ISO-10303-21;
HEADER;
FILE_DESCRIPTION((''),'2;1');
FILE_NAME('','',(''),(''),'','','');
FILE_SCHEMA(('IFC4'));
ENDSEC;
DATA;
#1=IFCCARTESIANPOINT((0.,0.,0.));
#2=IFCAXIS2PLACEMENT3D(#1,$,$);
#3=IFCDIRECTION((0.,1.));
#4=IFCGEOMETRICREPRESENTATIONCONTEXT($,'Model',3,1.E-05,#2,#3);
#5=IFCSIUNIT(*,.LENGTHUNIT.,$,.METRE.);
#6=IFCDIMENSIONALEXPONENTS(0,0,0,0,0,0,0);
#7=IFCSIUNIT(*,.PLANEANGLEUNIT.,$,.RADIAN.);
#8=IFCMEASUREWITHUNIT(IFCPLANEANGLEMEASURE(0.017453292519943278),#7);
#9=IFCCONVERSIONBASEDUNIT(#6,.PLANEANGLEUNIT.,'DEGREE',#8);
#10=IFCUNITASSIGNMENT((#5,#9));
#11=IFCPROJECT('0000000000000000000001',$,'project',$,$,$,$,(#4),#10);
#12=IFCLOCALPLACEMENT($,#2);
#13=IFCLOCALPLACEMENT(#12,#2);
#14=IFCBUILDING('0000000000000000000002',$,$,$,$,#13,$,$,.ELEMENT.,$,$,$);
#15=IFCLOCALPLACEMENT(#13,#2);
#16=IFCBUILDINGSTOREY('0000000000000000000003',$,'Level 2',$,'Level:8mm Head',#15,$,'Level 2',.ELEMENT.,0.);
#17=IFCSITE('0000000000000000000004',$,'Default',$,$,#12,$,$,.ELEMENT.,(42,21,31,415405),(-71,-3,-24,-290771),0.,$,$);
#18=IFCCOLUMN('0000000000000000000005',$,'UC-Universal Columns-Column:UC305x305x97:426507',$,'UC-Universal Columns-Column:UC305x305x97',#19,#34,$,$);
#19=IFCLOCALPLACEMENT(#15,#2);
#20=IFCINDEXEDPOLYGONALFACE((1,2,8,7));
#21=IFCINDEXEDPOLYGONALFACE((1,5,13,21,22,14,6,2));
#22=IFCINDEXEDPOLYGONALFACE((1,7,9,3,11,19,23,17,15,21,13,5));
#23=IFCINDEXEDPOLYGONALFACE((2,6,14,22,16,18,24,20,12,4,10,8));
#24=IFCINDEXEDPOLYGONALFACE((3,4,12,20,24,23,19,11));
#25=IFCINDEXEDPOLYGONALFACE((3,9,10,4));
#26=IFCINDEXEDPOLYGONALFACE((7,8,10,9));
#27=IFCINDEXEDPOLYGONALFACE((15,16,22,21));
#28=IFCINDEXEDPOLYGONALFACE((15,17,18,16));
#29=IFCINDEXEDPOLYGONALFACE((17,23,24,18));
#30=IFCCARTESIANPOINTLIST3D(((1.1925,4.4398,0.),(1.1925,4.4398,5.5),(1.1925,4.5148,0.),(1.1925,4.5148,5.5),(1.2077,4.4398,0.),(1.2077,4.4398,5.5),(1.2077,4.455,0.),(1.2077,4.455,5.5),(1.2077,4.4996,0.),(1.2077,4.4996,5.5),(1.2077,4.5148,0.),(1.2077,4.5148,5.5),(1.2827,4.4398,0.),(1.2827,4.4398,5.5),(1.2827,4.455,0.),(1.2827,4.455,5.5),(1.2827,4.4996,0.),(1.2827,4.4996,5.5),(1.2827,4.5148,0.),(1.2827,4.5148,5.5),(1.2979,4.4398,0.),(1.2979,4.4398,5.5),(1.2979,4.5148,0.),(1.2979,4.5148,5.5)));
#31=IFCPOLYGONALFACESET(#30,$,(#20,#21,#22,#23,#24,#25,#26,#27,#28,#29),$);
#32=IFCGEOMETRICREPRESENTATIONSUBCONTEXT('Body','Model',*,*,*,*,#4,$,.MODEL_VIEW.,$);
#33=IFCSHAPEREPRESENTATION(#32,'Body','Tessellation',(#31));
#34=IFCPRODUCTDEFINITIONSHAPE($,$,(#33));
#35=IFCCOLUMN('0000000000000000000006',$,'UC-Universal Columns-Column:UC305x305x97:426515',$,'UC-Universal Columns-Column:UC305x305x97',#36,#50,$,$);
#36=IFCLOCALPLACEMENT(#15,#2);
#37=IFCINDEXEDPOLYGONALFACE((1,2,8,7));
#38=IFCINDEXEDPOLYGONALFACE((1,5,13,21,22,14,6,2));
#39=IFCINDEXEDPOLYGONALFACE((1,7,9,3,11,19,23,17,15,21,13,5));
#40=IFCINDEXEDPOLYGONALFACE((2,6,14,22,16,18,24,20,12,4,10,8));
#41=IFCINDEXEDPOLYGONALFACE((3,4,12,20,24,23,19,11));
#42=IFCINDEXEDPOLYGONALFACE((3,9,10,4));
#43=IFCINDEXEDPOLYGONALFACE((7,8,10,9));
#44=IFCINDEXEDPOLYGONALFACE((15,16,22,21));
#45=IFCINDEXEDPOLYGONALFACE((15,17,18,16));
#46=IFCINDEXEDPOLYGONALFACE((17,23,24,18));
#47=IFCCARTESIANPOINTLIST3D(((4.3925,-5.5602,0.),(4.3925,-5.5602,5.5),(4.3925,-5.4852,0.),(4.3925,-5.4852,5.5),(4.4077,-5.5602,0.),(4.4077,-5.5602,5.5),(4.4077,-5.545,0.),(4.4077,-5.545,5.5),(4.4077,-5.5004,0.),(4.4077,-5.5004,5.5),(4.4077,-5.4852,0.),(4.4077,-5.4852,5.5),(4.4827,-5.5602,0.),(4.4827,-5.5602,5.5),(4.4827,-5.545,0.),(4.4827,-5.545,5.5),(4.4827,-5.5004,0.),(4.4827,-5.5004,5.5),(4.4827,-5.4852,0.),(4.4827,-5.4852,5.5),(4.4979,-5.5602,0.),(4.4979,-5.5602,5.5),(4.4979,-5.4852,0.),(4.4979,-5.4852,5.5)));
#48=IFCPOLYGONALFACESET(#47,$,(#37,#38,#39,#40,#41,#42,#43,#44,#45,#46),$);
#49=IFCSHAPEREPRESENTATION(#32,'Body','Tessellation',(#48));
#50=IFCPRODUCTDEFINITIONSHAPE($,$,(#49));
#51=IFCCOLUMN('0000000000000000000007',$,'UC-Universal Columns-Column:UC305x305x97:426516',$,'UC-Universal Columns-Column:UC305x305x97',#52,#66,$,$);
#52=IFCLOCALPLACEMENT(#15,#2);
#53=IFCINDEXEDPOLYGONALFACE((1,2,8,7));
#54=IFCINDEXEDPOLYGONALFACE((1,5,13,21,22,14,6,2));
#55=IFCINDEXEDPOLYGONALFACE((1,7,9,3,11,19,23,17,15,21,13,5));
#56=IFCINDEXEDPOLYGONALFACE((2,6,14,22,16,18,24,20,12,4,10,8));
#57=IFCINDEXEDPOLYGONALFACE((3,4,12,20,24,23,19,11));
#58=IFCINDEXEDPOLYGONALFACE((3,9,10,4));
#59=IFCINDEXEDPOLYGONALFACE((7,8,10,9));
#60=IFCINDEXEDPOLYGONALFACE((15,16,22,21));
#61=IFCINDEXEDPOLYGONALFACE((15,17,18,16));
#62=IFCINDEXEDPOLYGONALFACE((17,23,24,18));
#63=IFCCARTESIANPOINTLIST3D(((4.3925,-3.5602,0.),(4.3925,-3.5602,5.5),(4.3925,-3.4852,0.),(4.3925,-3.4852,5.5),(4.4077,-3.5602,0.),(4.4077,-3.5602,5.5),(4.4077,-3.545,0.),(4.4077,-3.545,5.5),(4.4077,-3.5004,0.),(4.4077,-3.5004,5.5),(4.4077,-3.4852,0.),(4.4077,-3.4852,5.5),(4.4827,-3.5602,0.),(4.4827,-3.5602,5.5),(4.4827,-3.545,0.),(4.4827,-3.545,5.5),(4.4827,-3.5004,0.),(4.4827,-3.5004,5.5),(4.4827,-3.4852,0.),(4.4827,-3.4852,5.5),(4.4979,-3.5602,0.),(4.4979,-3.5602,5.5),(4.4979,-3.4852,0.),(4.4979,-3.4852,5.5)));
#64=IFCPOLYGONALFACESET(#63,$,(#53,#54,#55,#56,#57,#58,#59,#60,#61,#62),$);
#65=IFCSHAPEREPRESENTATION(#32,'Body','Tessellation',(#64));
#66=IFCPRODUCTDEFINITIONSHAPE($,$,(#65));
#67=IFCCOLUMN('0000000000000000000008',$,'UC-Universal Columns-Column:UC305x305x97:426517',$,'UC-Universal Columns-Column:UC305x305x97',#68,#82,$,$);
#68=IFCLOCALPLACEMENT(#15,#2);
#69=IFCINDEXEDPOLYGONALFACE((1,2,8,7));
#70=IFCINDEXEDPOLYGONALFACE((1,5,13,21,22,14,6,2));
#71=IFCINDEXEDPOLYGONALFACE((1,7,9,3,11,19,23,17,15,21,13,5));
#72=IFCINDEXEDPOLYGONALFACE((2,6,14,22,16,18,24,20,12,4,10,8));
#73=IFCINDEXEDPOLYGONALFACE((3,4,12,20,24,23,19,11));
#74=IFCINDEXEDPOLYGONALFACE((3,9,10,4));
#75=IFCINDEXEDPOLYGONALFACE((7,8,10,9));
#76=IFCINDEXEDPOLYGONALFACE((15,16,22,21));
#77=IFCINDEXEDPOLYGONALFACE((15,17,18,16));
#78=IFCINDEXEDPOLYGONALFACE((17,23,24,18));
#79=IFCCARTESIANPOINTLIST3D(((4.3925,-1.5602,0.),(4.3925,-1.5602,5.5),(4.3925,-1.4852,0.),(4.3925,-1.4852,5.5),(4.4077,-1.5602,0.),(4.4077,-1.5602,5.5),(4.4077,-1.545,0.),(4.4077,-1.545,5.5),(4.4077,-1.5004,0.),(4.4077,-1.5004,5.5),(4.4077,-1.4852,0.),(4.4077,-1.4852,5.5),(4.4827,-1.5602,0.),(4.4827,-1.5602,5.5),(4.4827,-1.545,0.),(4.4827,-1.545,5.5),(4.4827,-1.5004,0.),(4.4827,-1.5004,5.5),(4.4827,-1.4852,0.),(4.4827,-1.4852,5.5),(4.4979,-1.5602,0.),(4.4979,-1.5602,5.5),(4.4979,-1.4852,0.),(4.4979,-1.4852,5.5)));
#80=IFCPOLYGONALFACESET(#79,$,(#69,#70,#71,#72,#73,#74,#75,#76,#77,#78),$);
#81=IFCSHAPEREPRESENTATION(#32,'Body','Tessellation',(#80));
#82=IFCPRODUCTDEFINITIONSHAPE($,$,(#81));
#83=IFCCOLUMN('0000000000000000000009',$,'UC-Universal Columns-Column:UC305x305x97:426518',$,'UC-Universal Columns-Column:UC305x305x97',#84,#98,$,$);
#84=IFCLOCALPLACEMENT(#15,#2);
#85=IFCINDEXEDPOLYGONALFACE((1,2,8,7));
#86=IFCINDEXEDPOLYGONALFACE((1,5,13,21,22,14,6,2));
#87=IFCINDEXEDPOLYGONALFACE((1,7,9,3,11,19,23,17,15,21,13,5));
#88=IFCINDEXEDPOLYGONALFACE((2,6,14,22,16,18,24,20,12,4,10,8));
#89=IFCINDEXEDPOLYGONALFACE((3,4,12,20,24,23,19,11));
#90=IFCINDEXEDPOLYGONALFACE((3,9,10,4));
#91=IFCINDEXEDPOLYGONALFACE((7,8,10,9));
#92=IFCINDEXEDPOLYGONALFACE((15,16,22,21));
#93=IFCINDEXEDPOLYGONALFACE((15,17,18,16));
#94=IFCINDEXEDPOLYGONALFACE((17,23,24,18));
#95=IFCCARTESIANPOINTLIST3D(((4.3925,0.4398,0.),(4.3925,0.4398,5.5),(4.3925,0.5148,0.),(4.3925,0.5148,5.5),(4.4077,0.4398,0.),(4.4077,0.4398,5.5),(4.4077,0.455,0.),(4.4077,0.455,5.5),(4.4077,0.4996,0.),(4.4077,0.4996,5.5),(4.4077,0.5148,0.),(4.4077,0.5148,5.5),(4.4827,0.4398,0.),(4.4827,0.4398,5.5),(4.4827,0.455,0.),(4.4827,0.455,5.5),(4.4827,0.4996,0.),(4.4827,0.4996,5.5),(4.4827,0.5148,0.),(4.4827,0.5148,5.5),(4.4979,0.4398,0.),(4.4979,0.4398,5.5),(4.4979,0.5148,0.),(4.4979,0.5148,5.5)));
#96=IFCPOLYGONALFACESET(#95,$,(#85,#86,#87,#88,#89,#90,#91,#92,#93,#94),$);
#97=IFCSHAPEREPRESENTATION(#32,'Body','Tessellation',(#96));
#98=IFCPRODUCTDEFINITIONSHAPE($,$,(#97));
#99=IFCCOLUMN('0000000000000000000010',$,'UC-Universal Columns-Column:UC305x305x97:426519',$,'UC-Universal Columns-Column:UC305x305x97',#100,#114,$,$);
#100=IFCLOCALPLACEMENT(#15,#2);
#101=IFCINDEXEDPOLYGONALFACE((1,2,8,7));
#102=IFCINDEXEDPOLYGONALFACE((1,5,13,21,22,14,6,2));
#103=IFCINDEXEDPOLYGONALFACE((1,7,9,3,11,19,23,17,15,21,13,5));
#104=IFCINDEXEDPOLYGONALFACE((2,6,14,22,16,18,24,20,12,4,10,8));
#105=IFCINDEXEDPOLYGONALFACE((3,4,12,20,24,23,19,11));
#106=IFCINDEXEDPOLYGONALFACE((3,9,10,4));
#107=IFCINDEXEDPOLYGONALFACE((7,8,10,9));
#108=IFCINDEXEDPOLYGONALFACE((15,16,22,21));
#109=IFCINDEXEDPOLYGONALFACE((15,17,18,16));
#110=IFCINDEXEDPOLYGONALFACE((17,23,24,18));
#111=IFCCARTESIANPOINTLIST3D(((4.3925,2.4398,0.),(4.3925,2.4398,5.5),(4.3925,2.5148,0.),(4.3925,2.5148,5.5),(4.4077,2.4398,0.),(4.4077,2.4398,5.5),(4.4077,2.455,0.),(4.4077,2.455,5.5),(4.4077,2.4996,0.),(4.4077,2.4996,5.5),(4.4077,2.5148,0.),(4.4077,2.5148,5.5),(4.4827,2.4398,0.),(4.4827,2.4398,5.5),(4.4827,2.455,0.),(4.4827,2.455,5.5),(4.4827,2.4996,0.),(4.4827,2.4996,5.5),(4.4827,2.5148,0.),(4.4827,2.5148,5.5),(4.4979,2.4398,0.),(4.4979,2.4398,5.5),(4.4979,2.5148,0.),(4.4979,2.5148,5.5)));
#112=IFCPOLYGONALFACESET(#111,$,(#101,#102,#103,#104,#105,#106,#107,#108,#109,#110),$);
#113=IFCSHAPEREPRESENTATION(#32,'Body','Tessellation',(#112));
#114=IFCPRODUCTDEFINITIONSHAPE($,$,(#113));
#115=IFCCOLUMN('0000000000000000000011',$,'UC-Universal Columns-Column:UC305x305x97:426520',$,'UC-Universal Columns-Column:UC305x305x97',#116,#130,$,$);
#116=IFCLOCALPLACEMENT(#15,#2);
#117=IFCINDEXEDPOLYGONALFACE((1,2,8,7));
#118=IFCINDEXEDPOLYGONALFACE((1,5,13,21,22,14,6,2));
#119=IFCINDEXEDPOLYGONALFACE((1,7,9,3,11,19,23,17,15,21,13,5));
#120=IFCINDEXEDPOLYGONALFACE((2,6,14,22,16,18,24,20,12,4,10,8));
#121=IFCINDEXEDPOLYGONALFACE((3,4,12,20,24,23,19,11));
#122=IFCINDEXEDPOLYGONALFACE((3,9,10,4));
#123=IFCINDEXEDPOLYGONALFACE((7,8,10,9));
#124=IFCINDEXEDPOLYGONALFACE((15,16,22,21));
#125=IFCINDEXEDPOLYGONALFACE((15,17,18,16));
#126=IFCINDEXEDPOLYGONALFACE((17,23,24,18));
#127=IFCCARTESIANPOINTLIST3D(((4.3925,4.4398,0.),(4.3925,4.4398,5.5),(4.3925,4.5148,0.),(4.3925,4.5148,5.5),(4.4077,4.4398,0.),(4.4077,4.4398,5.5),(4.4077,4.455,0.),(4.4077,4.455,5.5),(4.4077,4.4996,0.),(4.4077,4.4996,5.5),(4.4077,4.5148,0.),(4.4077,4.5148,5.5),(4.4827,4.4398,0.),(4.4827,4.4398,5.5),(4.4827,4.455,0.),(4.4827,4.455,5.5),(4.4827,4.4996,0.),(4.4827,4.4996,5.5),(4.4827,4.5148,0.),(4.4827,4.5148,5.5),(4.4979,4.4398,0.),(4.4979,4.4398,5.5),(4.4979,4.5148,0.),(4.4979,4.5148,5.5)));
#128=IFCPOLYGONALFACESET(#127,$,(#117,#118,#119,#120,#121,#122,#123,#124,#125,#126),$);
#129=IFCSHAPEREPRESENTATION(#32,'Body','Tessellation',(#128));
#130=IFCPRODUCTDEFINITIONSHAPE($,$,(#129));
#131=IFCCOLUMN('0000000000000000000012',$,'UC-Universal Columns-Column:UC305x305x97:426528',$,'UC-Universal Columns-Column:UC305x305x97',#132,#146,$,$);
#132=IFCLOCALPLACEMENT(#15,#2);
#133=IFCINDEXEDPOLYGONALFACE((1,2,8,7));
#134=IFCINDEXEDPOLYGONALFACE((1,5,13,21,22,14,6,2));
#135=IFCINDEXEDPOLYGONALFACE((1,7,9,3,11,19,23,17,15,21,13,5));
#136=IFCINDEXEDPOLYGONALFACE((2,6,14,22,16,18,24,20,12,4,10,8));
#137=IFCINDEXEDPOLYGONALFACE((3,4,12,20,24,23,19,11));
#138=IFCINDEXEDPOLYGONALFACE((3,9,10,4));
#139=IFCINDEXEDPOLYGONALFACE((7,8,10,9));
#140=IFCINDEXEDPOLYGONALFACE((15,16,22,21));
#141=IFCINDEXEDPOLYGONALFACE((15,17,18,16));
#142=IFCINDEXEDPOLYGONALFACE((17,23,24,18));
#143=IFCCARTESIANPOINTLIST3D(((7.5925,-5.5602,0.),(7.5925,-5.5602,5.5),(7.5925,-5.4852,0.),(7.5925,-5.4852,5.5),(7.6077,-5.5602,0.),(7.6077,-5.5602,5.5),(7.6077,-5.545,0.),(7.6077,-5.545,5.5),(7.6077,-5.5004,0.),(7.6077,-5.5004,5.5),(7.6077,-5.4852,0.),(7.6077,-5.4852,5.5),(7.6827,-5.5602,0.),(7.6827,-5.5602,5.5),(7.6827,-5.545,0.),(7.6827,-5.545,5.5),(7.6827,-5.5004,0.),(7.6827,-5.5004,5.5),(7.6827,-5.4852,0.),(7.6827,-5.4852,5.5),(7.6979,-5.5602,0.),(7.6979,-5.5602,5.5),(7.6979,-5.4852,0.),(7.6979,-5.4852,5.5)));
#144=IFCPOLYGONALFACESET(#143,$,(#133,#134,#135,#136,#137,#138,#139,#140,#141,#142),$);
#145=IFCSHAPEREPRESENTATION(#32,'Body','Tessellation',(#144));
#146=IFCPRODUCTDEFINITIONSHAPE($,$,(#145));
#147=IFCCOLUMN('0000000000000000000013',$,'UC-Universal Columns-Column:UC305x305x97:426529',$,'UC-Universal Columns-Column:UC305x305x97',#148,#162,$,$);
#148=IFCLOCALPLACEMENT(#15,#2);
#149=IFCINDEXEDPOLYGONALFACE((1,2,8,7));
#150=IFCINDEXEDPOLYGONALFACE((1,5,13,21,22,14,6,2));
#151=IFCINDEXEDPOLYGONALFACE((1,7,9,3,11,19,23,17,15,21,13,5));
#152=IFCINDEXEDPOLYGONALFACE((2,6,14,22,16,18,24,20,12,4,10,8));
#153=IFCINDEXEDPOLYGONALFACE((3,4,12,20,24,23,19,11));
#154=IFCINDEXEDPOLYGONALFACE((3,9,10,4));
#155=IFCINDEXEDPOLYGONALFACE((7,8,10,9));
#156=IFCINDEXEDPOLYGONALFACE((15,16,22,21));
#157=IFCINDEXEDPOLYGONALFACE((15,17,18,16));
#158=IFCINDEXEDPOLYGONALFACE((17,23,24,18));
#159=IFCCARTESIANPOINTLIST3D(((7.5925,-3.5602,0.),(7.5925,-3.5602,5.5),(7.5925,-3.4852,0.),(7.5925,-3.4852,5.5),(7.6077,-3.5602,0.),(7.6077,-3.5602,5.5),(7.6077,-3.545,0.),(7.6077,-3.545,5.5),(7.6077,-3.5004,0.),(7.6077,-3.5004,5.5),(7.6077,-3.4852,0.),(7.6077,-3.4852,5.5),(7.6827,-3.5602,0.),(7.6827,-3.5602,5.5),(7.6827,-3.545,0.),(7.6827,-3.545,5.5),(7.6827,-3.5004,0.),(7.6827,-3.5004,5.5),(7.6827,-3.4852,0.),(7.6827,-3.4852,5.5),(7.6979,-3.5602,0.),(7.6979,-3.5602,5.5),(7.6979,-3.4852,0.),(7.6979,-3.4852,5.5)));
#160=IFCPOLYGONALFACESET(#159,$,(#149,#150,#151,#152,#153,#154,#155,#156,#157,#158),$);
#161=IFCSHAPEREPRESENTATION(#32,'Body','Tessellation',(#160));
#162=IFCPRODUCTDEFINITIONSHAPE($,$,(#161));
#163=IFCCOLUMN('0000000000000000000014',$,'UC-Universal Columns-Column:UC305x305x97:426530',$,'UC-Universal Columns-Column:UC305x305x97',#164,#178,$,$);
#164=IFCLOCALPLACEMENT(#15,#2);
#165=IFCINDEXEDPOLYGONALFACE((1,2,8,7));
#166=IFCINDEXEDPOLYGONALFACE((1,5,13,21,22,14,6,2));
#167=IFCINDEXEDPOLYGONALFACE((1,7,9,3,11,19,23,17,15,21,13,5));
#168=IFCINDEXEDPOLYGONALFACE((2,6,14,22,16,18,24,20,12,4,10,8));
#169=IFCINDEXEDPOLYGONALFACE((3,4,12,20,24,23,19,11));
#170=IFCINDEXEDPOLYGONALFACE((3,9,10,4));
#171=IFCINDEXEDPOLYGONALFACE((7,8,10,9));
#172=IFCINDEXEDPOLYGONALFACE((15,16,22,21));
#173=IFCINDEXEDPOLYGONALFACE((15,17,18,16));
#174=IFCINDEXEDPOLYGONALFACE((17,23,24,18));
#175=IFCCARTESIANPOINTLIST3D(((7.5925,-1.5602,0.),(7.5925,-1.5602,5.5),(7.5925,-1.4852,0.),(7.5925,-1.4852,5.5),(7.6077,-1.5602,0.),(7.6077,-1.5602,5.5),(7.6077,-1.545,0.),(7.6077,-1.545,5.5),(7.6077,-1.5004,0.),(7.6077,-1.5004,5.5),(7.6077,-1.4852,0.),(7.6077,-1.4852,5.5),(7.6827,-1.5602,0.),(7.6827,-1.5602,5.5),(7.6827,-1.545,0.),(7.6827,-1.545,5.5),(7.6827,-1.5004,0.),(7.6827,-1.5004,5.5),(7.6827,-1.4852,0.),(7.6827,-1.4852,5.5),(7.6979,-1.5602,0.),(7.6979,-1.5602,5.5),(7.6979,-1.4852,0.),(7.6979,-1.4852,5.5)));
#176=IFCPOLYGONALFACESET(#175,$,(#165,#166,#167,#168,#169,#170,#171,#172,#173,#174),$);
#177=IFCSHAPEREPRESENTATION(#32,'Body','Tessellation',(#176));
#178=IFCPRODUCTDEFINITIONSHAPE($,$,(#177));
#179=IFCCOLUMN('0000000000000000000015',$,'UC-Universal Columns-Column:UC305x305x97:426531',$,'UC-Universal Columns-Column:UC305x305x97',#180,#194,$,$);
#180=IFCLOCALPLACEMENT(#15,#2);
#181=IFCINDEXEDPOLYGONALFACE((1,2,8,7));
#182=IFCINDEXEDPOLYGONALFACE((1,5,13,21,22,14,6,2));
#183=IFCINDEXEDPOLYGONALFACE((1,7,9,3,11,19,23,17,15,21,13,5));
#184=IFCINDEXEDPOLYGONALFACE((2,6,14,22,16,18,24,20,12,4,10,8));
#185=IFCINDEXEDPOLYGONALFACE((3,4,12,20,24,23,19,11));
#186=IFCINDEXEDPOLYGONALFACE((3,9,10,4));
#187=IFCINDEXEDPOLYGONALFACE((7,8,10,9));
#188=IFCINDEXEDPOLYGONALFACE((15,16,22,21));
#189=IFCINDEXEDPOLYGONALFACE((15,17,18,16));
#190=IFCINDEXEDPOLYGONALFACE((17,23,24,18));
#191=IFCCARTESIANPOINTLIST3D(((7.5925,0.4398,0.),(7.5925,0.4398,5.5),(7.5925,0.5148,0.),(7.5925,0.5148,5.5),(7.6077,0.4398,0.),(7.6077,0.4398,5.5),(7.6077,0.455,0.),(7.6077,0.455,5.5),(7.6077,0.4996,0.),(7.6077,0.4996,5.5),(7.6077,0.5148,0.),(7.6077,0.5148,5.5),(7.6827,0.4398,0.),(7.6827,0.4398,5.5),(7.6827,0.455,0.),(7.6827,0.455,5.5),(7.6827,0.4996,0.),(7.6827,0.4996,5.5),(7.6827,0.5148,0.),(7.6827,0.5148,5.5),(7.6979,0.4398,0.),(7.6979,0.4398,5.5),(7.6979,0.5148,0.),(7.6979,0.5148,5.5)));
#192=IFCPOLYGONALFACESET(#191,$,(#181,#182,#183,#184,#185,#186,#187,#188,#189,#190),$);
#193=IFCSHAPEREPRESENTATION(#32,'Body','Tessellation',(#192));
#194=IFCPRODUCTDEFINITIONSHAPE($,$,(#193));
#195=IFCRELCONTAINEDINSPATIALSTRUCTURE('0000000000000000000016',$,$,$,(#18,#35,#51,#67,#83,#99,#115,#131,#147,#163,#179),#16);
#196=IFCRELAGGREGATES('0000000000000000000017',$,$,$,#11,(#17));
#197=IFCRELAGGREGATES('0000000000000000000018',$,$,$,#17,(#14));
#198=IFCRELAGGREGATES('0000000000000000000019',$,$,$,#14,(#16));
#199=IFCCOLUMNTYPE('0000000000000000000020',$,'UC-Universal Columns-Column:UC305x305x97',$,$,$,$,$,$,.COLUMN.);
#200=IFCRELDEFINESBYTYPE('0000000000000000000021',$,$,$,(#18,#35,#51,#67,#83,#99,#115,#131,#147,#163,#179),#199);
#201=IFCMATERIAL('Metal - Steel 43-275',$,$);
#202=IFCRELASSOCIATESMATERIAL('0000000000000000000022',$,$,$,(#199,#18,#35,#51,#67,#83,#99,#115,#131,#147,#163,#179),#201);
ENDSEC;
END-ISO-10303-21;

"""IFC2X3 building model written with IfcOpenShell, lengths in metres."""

from ifc_helpers import new_model, entity, si_unit, converted_unit, direction, frame, frame_2d, origin, place, context, subcontext, project, spatial, polyline, circle_curve, parameter, trimmed, segment, composite_curve, outline, extrude, source, transform, mapped, material, type_object, type_shapes, element, save


model = new_model("IFC2X3")

# Units and contexts
model_context = context("Model", 3, precision=1e-05, world=origin(), true_north=direction((0.0, 1.0)))
body_context = subcontext(model_context, "Body", "Model", "MODEL_VIEW")
ifc_project = project(units=[si_unit("LENGTHUNIT", "METRE"), converted_unit("PLANEANGLEUNIT", "DEGREE", entity("IfcPlaneAngleMeasure", 0.017453292519943278), si_unit("PLANEANGLEUNIT", "RADIAN"), dimensions=[0, 0, 0, 0, 0, 0, 0])], contexts=[model_context])

# Site, building, storey
site_placement = place(None, origin())
site = spatial("IfcSite", under=ifc_project, at=site_placement, Name="Default", CompositionType="ELEMENT", RefLatitude=(42, 21, 31, 415405), RefLongitude=(-71, -3, -24, -290771), RefElevation=0.0)
building_placement = place(site_placement, origin())
building = spatial("IfcBuilding", under=site, at=building_placement, CompositionType="ELEMENT")
storey_placement = place(building_placement, origin())
storey = spatial("IfcBuildingStorey", under=building, at=storey_placement, Name="Level 2", ObjectType="Level:8mm Head", LongName="Level 2", CompositionType="ELEMENT", Elevation=0.0)

# Columns
ifc_material_1 = material(Name="Metal - Steel 43-275")
column_type_1 = type_object("IfcColumnType", Name="UC-Universal Columns-Column:UC305x305x97", PredefinedType="COLUMN", material=ifc_material_1)
shared_shape_1 = source(origin(), body_context, "Body", "SweptSolid", [
    extrude(outline(composite_curve([segment(polyline([(-0.0375, -0.0375), (0.0375, -0.0375)]), True, "CONTINUOUS"), segment(polyline([(0.0375, -0.0375), (0.0527, -0.0375)]), True, "CONTINUOUS"), segment(trimmed(circle_curve(frame_2d((0.0527, -0.0223), x_axis=(-1.0, 0.0)), 0.0152), [parameter(0.0)], [parameter(90.0)], True, "PARAMETER"), False, "CONTINUOUS"), segment(polyline([(0.0375, -0.0223), (0.0375, 0.0223)]), True, "CONTINUOUS"), segment(trimmed(circle_curve(frame_2d((0.0527, 0.0223), x_axis=(-1.0, 0.0)), 0.0152), [parameter(270.0)], [parameter(0.0)], True, "PARAMETER"), False, "CONTINUOUS"), segment(polyline([(0.0527, 0.0375), (0.0375, 0.0375)]), True, "CONTINUOUS"), segment(polyline([(0.0375, 0.0375), (-0.0375, 0.0375)]), True, "CONTINUOUS"), segment(polyline([(-0.0375, 0.0375), (-0.0527, 0.0375)]), True, "CONTINUOUS"), segment(trimmed(circle_curve(frame_2d((-0.0527, 0.0223), x_axis=(-1.0, 0.0)), 0.0152), [parameter(180.0)], [parameter(270.0)], True, "PARAMETER"), False, "CONTINUOUS"), segment(polyline([(-0.0375, 0.0223), (-0.0375, -0.0223)]), True, "CONTINUOUS"), segment(trimmed(circle_curve(frame_2d((-0.0527, -0.0223), x_axis=(-1.0, 0.0)), 0.0152), [parameter(90.0)], [parameter(180.0)], True, "PARAMETER"), False, "CONTINUOUS"), segment(polyline([(-0.0527, -0.0375), (-0.0375, -0.0375)]), True, "CONTINUOUS")], self_intersect=False)), frame((0.0, 0.0, 0.0), z_axis=(0.0, 0.0, 1.0), x_axis=(-1.0, 0.0, 0.0)), (0.0, 0.0, 1.0), 5.5),
])
type_shapes(column_type_1, [shared_shape_1])
for number, where, z_axis, x_axis, name in (
    (1, (1.2452, 4.4773, 0.0), (0.0, 0.0, 1.0), (-1.0, 0.0, 0.0), "UC-Universal Columns-Column:UC305x305x97:426507"),
    (2, (4.4452, -5.5227, 0.0), (0.0, 0.0, 1.0), (-1.0, 0.0, 0.0), "UC-Universal Columns-Column:UC305x305x97:426515"),
    (3, (4.4452, -3.5227, 0.0), (0.0, 0.0, 1.0), (-1.0, 0.0, 0.0), "UC-Universal Columns-Column:UC305x305x97:426516"),
    (4, (4.4452, -1.5227, 0.0), (0.0, 0.0, 1.0), (-1.0, 0.0, 0.0), "UC-Universal Columns-Column:UC305x305x97:426517"),
    (5, (4.4452, 0.4773, 0.0), (0.0, 0.0, 1.0), (-1.0, 0.0, 0.0), "UC-Universal Columns-Column:UC305x305x97:426518"),
    (6, (4.4452, 2.4773, 0.0), (0.0, 0.0, 1.0), (-1.0, 0.0, 0.0), "UC-Universal Columns-Column:UC305x305x97:426519"),
    (7, (4.4452, 4.4773, 0.0), (0.0, 0.0, 1.0), (-1.0, 0.0, 0.0), "UC-Universal Columns-Column:UC305x305x97:426520"),
    (8, (7.6452, -5.5227, 0.0), (0.0, 0.0, 1.0), (-1.0, 0.0, 0.0), "UC-Universal Columns-Column:UC305x305x97:426528"),
    (9, (7.6452, -3.5227, 0.0), (0.0, 0.0, 1.0), (-1.0, 0.0, 0.0), "UC-Universal Columns-Column:UC305x305x97:426529"),
    (10, (7.6452, -1.5227, 0.0), (0.0, 0.0, 1.0), (-1.0, 0.0, 0.0), "UC-Universal Columns-Column:UC305x305x97:426530"),
    (11, (7.6452, 0.4773, 0.0), (0.0, 0.0, 1.0), (-1.0, 0.0, 0.0), "UC-Universal Columns-Column:UC305x305x97:426531"),
):
    element("IfcColumn", number, at=place(storey_placement, frame(where, z_axis=z_axis, x_axis=x_axis)), inside=storey, type_object=column_type_1, material=ifc_material_1, Name=name, ObjectType="UC-Universal Columns-Column:UC305x305x97", context=body_context, shape_type="MappedRepresentation", body=[
        mapped(shared_shape_1, transform((0.0, 0.0, 0.0), scale=1.0)),
    ])

save(model, "model.ifc")
